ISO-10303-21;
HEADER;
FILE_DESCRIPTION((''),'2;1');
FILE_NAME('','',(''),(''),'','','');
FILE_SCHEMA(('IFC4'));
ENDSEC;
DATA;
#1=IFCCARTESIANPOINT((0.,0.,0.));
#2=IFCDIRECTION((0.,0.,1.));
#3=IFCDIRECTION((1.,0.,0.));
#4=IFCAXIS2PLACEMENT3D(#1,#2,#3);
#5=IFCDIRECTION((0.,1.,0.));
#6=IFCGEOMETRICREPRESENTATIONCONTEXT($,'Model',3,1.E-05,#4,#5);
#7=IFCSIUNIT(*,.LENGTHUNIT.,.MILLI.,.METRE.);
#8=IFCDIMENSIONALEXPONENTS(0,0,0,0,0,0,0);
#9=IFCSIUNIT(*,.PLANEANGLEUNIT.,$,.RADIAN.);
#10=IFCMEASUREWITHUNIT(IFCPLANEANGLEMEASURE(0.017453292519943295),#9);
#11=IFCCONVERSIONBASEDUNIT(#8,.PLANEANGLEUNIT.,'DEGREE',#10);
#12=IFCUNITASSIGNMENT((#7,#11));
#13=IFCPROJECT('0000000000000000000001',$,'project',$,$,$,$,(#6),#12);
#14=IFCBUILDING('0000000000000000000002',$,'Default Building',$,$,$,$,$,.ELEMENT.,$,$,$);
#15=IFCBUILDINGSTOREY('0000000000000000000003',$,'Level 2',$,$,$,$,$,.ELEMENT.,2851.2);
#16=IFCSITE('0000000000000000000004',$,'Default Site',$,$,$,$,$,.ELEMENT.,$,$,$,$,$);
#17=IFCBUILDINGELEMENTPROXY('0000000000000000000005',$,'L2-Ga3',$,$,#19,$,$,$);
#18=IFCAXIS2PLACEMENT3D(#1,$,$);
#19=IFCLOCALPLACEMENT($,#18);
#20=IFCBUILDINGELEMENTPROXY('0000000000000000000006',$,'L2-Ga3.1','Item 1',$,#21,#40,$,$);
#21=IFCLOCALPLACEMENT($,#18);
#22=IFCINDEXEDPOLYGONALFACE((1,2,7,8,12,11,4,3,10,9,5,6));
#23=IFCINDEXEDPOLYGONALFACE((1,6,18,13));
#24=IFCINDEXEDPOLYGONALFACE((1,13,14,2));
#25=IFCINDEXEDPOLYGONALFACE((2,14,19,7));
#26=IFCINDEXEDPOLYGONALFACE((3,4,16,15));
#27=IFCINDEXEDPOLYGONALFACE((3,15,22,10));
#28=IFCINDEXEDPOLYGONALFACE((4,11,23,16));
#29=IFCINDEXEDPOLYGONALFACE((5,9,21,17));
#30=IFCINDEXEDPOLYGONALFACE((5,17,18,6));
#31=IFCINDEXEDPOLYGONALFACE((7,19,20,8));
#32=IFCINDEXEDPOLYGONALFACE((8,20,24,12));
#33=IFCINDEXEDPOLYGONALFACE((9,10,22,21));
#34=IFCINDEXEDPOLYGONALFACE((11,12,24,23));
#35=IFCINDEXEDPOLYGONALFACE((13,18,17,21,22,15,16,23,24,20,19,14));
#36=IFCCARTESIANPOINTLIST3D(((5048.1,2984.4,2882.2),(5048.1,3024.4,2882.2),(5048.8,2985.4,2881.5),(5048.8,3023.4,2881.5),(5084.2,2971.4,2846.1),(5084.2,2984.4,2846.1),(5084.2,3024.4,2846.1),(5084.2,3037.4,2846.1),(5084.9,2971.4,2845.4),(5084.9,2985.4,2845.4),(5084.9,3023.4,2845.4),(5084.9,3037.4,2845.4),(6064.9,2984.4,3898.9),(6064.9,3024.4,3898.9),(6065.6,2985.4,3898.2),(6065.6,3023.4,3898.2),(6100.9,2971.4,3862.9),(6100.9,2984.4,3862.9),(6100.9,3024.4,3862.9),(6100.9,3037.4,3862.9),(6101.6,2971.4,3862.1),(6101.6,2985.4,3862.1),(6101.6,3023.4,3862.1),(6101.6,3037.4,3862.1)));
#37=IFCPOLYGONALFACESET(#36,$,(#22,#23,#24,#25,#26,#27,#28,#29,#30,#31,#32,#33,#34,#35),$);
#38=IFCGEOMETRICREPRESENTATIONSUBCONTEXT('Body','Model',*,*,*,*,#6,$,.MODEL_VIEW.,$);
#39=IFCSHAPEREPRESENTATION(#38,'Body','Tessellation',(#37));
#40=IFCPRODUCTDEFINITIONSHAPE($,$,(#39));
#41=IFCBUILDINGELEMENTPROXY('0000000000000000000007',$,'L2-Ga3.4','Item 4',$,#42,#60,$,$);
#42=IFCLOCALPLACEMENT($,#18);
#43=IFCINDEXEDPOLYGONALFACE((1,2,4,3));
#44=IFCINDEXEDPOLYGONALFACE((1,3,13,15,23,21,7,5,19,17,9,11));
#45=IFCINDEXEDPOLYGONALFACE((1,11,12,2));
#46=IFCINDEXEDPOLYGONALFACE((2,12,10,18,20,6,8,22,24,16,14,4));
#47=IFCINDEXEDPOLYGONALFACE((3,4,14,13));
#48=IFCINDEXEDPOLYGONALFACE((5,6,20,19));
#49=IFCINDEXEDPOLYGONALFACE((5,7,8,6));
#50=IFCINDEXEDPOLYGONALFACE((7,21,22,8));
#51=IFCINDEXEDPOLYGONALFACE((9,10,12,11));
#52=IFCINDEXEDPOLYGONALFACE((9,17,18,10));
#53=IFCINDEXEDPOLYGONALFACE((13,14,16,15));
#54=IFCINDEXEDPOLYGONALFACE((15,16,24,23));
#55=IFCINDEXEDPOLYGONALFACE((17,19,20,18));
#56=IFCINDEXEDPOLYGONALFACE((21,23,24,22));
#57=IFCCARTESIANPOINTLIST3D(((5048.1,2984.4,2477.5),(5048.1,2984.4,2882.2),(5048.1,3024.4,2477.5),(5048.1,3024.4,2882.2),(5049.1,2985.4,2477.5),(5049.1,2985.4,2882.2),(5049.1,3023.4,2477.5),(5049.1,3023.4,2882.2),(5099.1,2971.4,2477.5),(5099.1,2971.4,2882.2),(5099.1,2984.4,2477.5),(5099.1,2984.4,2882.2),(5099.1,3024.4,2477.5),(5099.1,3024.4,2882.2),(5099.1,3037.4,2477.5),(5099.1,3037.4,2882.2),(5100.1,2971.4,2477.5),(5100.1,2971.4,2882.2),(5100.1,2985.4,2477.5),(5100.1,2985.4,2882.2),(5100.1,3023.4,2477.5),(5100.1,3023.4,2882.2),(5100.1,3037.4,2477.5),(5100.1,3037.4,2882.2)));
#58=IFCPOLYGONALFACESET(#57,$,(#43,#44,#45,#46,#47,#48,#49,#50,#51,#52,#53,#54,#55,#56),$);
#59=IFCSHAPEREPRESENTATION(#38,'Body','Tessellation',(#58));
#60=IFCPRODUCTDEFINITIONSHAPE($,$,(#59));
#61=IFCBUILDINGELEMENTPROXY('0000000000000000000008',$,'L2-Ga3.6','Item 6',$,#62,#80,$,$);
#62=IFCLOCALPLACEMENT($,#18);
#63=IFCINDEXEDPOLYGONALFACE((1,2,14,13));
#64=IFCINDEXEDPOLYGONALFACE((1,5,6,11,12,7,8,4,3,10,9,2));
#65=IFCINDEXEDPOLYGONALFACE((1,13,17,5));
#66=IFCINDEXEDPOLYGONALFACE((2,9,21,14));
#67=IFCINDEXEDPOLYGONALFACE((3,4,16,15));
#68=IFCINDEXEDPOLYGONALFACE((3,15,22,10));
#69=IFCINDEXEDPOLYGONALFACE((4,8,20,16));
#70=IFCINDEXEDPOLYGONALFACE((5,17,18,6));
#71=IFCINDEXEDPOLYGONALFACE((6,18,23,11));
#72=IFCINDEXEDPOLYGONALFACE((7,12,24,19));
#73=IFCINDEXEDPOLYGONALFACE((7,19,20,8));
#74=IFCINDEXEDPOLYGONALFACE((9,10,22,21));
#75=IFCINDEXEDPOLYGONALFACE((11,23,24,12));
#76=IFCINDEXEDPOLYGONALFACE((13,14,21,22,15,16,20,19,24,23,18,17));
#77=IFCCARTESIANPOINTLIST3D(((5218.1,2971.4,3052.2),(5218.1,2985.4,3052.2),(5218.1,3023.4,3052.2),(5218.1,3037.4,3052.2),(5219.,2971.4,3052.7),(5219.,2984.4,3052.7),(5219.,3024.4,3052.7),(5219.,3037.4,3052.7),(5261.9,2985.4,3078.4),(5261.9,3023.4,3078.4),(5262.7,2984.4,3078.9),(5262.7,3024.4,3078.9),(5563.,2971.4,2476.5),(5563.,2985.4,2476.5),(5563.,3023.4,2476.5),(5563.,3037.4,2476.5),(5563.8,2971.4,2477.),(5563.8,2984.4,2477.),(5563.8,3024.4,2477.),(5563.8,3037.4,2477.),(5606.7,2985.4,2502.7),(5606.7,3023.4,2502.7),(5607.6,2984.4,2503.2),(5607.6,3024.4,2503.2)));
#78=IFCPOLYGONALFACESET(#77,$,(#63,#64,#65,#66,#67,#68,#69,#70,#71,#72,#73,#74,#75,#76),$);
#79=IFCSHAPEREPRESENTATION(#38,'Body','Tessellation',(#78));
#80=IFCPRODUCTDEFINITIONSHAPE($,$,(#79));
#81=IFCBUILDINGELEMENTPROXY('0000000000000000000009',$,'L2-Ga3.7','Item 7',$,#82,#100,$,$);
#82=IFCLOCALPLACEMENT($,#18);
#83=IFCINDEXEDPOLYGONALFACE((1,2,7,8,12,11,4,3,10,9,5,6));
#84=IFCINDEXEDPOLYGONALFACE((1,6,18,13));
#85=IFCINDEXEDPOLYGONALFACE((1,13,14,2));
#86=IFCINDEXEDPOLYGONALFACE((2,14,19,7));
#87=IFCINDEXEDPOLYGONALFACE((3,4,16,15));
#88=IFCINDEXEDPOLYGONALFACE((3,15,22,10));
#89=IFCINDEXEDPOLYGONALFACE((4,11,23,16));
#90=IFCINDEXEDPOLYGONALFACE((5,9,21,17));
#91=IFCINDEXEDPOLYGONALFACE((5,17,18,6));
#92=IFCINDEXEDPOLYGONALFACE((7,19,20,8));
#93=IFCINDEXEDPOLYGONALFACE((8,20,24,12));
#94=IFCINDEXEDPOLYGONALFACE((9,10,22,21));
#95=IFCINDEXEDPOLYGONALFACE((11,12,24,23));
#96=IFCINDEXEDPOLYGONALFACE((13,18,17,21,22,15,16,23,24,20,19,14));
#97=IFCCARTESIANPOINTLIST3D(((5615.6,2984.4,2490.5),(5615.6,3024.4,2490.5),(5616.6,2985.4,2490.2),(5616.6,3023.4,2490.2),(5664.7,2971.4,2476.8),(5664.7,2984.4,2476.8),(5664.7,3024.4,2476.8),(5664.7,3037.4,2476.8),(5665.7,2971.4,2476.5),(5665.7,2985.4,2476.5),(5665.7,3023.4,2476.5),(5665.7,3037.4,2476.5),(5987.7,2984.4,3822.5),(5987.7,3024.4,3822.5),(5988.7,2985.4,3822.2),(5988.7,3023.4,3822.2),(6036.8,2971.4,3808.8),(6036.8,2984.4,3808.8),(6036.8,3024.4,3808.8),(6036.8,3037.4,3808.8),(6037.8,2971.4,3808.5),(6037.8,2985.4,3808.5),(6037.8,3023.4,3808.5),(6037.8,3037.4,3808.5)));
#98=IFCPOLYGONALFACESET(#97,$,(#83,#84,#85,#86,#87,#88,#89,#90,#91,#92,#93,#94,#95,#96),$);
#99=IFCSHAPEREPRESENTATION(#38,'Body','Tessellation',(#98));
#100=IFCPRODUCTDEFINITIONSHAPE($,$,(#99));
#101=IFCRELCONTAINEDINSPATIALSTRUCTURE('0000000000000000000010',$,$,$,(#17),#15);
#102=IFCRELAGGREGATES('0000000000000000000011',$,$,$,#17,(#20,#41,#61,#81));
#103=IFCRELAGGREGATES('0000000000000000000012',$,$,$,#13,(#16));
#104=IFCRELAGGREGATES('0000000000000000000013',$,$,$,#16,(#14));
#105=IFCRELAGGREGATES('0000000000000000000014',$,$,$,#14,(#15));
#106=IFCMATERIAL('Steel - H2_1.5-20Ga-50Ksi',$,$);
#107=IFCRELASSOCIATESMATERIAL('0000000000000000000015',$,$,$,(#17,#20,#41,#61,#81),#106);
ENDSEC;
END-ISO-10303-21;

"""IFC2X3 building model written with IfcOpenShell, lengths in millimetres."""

from ifc_helpers import new_model, entity, si_unit, converted_unit, direction, frame, origin, origin_with_axes, place, context, subcontext, project, spatial, polyline, outline, extrude, material, element, aggregate, save


model = new_model("IFC2X3")

# Units and contexts
model_context = context("Model", 3, precision=1e-05, world=origin_with_axes(), true_north=direction((0.0, 1.0, 0.0)))
body_context = subcontext(model_context, "Body", "Model", "MODEL_VIEW")
ifc_project = project(units=[si_unit("LENGTHUNIT", "METRE", prefix="MILLI"), converted_unit("PLANEANGLEUNIT", "DEGREE", entity("IfcPlaneAngleMeasure", 0.017453292519943295), si_unit("PLANEANGLEUNIT", "RADIAN"), dimensions=[0, 0, 0, 0, 0, 0, 0])], contexts=[model_context])

# Site, building, storey
site = spatial("IfcSite", under=ifc_project, Name="Default Site", CompositionType="ELEMENT")
building = spatial("IfcBuilding", under=site, Name="Default Building", CompositionType="ELEMENT")
storey = spatial("IfcBuildingStorey", under=building, Name="Level 2", CompositionType="ELEMENT", Elevation=2851.2)

# Building element proxies
ifc_material_1 = material(Name="Steel - H2_1.5-20Ga-50Ksi")
proxy_1 = element("IfcBuildingElementProxy", 1, inside=storey, material=ifc_material_1, Name="L2-Ga3")
proxy_2_placement = place(None, frame((5084.9, 2971.4, 2845.4), z_axis=(0.707, 0.0, 0.707), x_axis=(0.0, 40.0, 0.0)))
proxy_2 = element("IfcBuildingElementProxy", 2, at=proxy_2_placement, material=ifc_material_1, Name="L2-Ga3.1", Description="Item 1", context=body_context, shape_type="SweptSolid", body=[
    extrude(outline(polyline([(0.0, 0.0), (14.0, 0.0), (14.0, 51.0), (52.0, 51.0), (52.0, 0.0), (66.0, 0.0), (66.0, 1.0), (53.0, 1.0), (53.0, 52.0), (13.0, 52.0), (13.0, 1.0), (0.0, 1.0), (0.0, 0.0)])), origin(), (0.0, 0.0, 1.0), 1437.9),
])
proxy_3_placement = place(None, frame((5100.1, 2971.4, 2477.5), z_axis=(0.0, 0.0, 1.0), x_axis=(0.0, 40.0, 0.0)))
proxy_3 = element("IfcBuildingElementProxy", 3, at=proxy_3_placement, material=ifc_material_1, Name="L2-Ga3.4", Description="Item 4", context=body_context, shape_type="SweptSolid", body=[
    extrude(outline(polyline([(0.0, 0.0), (14.0, 0.0), (14.0, 51.0), (52.0, 51.0), (52.0, 0.0), (66.0, 0.0), (66.0, 1.0), (53.0, 1.0), (53.0, 52.0), (13.0, 52.0), (13.0, 1.0), (0.0, 1.0), (0.0, 0.0)])), origin(), (0.0, 0.0, 1.0), 404.7),
])
proxy_4_placement = place(None, frame((5218.1, 2971.4, 3052.2), z_axis=(0.514, 0.0, -0.858), x_axis=(0.0, 40.0, 0.0)))
proxy_4 = element("IfcBuildingElementProxy", 4, at=proxy_4_placement, material=ifc_material_1, Name="L2-Ga3.6", Description="Item 6", context=body_context, shape_type="SweptSolid", body=[
    extrude(outline(polyline([(0.0, 0.0), (14.0, 0.0), (14.0, 51.0), (52.0, 51.0), (52.0, 0.0), (66.0, 0.0), (66.0, 1.0), (53.0, 1.0), (53.0, 52.0), (13.0, 52.0), (13.0, 1.0), (0.0, 1.0), (0.0, 0.0)])), origin(), (0.0, 0.0, 1.0), 671.1),
])
proxy_5_placement = place(None, frame((5665.7, 2971.4, 2476.5), z_axis=(0.269, 0.0, 0.963), x_axis=(0.0, 40.0, 0.0)))
proxy_5 = element("IfcBuildingElementProxy", 5, at=proxy_5_placement, material=ifc_material_1, Name="L2-Ga3.7", Description="Item 7", context=body_context, shape_type="SweptSolid", body=[
    extrude(outline(polyline([(0.0, 0.0), (14.0, 0.0), (14.0, 51.0), (52.0, 51.0), (52.0, 0.0), (66.0, 0.0), (66.0, 1.0), (53.0, 1.0), (53.0, 52.0), (13.0, 52.0), (13.0, 1.0), (0.0, 1.0), (0.0, 0.0)])), origin(), (0.0, 0.0, 1.0), 1383.0),
])
aggregate(proxy_1, [proxy_2, proxy_3, proxy_4, proxy_5])

save(model, "model.ifc")
